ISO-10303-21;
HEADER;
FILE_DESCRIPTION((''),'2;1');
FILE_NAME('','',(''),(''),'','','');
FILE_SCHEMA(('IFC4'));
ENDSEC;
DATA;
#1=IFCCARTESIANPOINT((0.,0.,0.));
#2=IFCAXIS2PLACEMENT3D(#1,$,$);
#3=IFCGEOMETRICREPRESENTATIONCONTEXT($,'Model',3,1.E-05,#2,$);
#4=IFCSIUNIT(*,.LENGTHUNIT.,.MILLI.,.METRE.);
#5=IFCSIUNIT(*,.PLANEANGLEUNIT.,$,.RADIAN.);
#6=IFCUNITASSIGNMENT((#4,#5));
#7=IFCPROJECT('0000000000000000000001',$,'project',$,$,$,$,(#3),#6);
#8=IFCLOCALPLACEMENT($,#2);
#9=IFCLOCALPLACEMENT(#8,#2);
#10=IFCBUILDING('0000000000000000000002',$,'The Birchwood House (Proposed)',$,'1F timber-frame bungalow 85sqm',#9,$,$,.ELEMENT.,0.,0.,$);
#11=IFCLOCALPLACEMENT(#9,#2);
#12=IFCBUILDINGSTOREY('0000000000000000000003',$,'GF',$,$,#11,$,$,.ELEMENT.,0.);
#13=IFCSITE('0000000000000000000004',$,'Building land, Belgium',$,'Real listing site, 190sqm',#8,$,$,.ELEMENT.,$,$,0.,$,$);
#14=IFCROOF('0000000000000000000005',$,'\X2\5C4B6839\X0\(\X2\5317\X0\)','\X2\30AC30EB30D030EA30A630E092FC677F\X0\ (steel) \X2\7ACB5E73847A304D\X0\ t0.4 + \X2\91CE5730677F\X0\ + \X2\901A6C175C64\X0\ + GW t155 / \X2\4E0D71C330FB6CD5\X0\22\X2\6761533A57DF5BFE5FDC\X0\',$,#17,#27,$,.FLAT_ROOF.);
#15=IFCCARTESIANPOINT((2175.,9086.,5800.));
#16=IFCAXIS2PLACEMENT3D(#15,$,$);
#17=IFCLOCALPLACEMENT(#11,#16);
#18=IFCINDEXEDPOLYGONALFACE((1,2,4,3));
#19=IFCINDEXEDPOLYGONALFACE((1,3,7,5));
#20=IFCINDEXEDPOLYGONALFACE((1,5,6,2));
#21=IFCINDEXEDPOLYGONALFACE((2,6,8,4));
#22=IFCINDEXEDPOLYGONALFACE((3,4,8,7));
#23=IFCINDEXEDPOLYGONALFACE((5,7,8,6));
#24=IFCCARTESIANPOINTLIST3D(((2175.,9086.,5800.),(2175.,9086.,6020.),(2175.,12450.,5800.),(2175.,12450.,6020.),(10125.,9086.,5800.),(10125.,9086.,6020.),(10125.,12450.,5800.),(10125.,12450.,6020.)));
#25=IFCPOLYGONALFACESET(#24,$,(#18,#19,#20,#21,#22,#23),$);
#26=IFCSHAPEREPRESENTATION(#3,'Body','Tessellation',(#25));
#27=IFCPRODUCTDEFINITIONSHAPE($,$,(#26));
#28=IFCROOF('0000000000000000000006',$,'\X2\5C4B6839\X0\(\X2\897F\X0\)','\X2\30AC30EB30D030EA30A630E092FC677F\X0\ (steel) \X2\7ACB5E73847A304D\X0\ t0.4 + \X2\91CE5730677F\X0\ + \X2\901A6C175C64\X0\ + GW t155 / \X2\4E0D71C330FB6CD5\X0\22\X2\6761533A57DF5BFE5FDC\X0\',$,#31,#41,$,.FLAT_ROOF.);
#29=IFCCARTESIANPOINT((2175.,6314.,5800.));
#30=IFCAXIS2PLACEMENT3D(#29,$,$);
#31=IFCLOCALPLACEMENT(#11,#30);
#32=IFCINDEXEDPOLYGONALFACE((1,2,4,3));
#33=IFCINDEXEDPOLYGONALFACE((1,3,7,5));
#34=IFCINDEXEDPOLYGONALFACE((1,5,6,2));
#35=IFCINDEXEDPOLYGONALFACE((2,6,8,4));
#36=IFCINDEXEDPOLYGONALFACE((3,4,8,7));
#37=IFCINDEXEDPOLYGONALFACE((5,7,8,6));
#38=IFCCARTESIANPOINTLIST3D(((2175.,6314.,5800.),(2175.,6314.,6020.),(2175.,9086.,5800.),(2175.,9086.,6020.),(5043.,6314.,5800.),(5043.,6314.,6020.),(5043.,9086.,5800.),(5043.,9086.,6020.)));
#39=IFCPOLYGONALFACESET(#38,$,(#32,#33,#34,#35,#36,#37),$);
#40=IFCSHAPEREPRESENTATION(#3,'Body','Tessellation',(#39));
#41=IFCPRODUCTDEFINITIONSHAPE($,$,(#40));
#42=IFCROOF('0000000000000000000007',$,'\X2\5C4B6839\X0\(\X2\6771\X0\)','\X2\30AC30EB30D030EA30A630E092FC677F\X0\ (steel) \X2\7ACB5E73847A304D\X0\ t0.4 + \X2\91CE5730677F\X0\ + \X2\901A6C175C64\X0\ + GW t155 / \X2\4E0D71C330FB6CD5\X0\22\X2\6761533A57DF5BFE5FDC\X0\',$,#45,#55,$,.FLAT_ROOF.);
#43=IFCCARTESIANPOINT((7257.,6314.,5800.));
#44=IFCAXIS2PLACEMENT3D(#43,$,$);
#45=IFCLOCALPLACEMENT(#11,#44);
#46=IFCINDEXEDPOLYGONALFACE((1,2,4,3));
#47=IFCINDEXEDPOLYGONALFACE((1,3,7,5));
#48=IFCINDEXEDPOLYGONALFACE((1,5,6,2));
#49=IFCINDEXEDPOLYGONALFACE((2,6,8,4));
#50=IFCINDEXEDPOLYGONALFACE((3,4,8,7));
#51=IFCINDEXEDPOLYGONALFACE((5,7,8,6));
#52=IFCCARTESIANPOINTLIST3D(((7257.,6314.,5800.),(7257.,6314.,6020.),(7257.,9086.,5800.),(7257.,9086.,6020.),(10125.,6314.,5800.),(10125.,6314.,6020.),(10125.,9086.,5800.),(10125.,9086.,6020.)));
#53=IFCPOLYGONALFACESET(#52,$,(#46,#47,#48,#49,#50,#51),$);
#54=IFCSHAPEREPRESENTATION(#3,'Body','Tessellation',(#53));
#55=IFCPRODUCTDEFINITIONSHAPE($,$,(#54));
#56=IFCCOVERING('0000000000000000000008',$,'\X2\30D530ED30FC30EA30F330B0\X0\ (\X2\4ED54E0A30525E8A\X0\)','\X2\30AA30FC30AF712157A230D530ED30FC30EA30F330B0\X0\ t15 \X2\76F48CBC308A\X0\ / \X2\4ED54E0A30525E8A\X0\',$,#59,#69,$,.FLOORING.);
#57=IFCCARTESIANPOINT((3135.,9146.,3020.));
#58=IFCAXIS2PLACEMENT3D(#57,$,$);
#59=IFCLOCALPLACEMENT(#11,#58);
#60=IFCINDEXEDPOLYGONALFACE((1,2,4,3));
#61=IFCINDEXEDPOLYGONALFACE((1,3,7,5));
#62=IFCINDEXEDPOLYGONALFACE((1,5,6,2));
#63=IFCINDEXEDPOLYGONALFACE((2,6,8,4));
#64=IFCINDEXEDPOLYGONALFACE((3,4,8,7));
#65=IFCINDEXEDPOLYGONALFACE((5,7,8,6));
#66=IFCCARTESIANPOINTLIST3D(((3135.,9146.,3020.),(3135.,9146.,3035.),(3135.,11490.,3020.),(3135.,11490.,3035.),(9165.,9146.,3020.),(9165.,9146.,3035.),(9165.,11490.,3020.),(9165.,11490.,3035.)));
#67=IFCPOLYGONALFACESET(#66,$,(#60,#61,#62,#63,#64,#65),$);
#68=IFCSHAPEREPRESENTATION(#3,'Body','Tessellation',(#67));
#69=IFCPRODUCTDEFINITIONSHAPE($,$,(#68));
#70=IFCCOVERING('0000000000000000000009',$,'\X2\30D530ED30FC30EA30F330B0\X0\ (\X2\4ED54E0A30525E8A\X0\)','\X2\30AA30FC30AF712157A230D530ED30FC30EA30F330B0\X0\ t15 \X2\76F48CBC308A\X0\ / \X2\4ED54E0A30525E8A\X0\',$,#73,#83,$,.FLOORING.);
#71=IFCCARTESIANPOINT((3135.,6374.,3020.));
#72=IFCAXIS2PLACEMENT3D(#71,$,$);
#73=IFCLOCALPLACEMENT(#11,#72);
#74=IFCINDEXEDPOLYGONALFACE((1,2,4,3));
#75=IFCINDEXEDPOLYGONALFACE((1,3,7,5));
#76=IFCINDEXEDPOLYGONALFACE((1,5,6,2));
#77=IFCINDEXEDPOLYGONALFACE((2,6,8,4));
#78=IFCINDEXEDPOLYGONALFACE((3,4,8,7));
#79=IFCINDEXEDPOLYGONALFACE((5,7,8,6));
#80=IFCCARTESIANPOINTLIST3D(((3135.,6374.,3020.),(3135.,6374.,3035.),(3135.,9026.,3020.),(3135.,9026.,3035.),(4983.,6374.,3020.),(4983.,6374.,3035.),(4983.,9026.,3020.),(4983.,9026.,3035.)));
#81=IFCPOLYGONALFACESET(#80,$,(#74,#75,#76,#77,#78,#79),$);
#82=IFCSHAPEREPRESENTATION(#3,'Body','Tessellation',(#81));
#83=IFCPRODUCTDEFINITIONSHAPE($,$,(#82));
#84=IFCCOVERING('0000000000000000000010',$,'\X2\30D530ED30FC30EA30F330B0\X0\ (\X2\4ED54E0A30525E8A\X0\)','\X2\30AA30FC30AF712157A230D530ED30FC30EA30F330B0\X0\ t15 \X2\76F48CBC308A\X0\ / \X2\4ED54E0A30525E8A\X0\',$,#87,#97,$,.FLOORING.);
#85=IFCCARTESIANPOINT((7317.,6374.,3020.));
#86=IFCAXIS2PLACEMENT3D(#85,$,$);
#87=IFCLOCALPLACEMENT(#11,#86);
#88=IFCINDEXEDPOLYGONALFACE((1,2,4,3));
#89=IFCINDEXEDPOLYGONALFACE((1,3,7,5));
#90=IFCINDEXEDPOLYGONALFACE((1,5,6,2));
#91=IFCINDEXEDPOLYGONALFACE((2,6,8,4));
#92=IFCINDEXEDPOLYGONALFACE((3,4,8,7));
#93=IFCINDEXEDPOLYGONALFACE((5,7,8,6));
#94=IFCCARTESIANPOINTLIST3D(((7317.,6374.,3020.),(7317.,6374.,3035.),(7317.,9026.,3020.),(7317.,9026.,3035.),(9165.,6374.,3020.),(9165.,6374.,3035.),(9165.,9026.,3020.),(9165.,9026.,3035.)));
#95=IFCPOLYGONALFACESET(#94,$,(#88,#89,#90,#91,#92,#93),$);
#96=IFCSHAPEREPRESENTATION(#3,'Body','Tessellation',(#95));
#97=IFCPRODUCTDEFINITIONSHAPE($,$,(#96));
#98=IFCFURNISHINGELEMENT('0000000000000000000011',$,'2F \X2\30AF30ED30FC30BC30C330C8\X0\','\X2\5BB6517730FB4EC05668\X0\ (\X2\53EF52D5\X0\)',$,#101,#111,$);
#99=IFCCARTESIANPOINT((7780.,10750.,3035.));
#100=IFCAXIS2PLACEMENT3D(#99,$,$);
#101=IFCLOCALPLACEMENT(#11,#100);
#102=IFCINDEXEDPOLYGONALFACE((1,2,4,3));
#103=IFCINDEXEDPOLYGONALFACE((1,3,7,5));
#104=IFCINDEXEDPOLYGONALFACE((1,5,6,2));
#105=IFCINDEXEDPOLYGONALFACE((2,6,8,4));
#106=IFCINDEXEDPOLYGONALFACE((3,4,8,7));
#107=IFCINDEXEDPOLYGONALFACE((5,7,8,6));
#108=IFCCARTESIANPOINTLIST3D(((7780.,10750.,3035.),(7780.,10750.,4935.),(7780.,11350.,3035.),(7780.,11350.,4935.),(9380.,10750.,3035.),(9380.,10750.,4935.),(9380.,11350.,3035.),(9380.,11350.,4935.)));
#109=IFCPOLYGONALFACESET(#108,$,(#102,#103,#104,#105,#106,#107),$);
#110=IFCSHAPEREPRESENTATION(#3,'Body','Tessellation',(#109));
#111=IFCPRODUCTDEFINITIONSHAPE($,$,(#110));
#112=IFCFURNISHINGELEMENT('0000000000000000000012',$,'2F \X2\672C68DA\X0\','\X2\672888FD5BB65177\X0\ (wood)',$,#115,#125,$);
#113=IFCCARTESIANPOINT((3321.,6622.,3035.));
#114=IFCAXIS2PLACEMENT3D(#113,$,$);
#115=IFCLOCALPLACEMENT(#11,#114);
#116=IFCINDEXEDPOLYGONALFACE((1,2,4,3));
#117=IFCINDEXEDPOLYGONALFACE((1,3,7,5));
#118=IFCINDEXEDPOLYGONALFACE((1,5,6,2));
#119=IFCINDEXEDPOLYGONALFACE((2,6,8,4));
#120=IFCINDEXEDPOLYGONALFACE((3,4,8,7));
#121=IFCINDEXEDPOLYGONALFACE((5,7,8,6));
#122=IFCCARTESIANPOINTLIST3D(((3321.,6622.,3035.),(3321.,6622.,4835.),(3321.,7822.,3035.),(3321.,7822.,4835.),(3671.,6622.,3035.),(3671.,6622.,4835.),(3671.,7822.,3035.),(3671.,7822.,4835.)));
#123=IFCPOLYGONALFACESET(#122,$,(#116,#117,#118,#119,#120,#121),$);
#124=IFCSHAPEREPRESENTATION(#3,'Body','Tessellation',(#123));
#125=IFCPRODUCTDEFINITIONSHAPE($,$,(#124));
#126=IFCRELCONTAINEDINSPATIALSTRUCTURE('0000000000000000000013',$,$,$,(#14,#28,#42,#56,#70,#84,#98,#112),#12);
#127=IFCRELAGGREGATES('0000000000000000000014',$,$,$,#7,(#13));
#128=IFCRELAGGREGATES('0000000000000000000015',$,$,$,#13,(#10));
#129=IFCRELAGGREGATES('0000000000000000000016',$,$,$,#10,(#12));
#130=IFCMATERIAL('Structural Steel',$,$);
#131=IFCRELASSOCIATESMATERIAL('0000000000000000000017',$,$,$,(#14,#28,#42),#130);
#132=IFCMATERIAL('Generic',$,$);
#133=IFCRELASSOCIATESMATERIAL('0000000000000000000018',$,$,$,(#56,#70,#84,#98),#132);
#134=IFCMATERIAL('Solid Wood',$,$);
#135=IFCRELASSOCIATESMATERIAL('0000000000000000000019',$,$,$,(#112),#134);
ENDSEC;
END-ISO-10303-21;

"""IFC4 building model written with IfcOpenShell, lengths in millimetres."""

from ifc_helpers import new_model, si_unit, frame, frame_2d, origin, place, context, project, spatial, rectangle, extrude, material, element, save


model = new_model("IFC4")

# Units and contexts
model_context = context("Model", 3, precision=1e-05, world=origin())
ifc_project = project(units=[si_unit("LENGTHUNIT", "METRE", prefix="MILLI"), si_unit("PLANEANGLEUNIT", "RADIAN")], contexts=[model_context])

# Site, building, storey
site_placement = place(None, origin())
site = spatial("IfcSite", under=ifc_project, at=site_placement, Name="Building land, Belgium", ObjectType="Real listing site, 190sqm", CompositionType="ELEMENT", RefElevation=0.0)
building_placement = place(site_placement, origin())
building = spatial("IfcBuilding", under=site, at=building_placement, Name="The Birchwood House (Proposed)", ObjectType="1F timber-frame bungalow 85sqm", CompositionType="ELEMENT", ElevationOfRefHeight=0.0, ElevationOfTerrain=0.0)
storey_placement = place(building_placement, origin())
storey = spatial("IfcBuildingStorey", under=building, at=storey_placement, Name="GF", CompositionType="ELEMENT", Elevation=0.0)

# Shared definitions
ifc_material_1 = material(Name="Solid Wood")

# Shared definitions
ifc_material_2 = material(Name="Generic")

# Roofs
ifc_material_3 = material(Name="Structural Steel")
for number, where, name in (
    (1, (2175.0, 9086.0, 5800.0), "屋根(北)"),
):
    element("IfcRoof", number, at=place(storey_placement, frame(where)), inside=storey, material=ifc_material_3, Name=name, Description="ガルバリウム鋼板 (steel) 立平葺き t0.4 + 野地板 + 通気層 + GW t155 / 不燃・法22条区域対応", PredefinedType="FLAT_ROOF", context=model_context, shape_type="SweptSolid", body=[
        extrude(rectangle(XDim=7950.0, YDim=3364.0, at=frame_2d((3975.0, 1682.0))), frame((2175.0, 9086.0, 5800.0)), (0.0, 0.0, 1.0), 220.0),
    ])
roof_1_placement = place(storey_placement, frame((2175.0, 6314.0, 5800.0)))
element("IfcRoof", 2, at=roof_1_placement, inside=storey, material=ifc_material_3, Name="屋根(西)", Description="ガルバリウム鋼板 (steel) 立平葺き t0.4 + 野地板 + 通気層 + GW t155 / 不燃・法22条区域対応", PredefinedType="FLAT_ROOF", context=model_context, shape_type="SweptSolid", body=[
    extrude(rectangle(XDim=2868.0, YDim=2772.0, at=frame_2d((1434.0, 1386.0))), frame((2175.0, 6314.0, 5800.0)), (0.0, 0.0, 1.0), 220.0),
])
roof_2_placement = place(storey_placement, frame((7257.0, 6314.0, 5800.0)))
element("IfcRoof", 3, at=roof_2_placement, inside=storey, material=ifc_material_3, Name="屋根(東)", Description="ガルバリウム鋼板 (steel) 立平葺き t0.4 + 野地板 + 通気層 + GW t155 / 不燃・法22条区域対応", PredefinedType="FLAT_ROOF", context=model_context, shape_type="SweptSolid", body=[
    extrude(rectangle(XDim=2868.0, YDim=2772.0, at=frame_2d((1434.0, 1386.0))), frame((7257.0, 6314.0, 5800.0)), (0.0, 0.0, 1.0), 220.0),
])

# Coverings
covering_1_placement = place(storey_placement, frame((3135.0, 9146.0, 3020.0)))
element("IfcCovering", 4, at=covering_1_placement, inside=storey, material=ifc_material_2, Name="フローリング (仕上げ床)", Description="オーク無垢フローリング t15 直貼り / 仕上げ床", PredefinedType="FLOORING", context=model_context, shape_type="SweptSolid", body=[
    extrude(rectangle(XDim=6030.0, YDim=2344.0, at=frame_2d((3015.0, 1172.0))), frame((3135.0, 9146.0, 3020.0)), (0.0, 0.0, 1.0), 15.0),
])
covering_2_placement = place(storey_placement, frame((3135.0, 6374.0, 3020.0)))
element("IfcCovering", 5, at=covering_2_placement, inside=storey, material=ifc_material_2, Name="フローリング (仕上げ床)", Description="オーク無垢フローリング t15 直貼り / 仕上げ床", PredefinedType="FLOORING", context=model_context, shape_type="SweptSolid", body=[
    extrude(rectangle(XDim=1848.0, YDim=2652.0, at=frame_2d((924.0, 1326.0))), frame((3135.0, 6374.0, 3020.0)), (0.0, 0.0, 1.0), 15.0),
])
covering_3_placement = place(storey_placement, frame((7317.0, 6374.0, 3020.0)))
element("IfcCovering", 6, at=covering_3_placement, inside=storey, material=ifc_material_2, Name="フローリング (仕上げ床)", Description="オーク無垢フローリング t15 直貼り / 仕上げ床", PredefinedType="FLOORING", context=model_context, shape_type="SweptSolid", body=[
    extrude(rectangle(XDim=1848.0, YDim=2652.0, at=frame_2d((924.0, 1326.0))), frame((7317.0, 6374.0, 3020.0)), (0.0, 0.0, 1.0), 15.0),
])

# Furnishing elements
furnishing_1_placement = place(storey_placement, frame((7780.0, 10750.0, 3035.0)))
element("IfcFurnishingElement", 7, at=furnishing_1_placement, inside=storey, material=ifc_material_2, Name="2F クローゼット", Description="家具・什器 (可動)", context=model_context, shape_type="SweptSolid", body=[
    extrude(rectangle(XDim=1600.0, YDim=600.0, at=frame_2d((800.0, 300.0))), frame((7780.0, 10750.0, 3035.0)), (0.0, 0.0, 1.0), 1900.0),
])
furnishing_2_placement = place(storey_placement, frame((3321.0, 6622.0, 3035.0)))
element("IfcFurnishingElement", 8, at=furnishing_2_placement, inside=storey, material=ifc_material_1, Name="2F 本棚", Description="木製家具 (wood)", context=model_context, shape_type="SweptSolid", body=[
    extrude(rectangle(XDim=350.0, YDim=1200.0, at=frame_2d((175.0, 600.0))), frame((3321.0, 6622.0, 3035.0)), (0.0, 0.0, 1.0), 1800.0),
])

save(model, "model.ifc")
